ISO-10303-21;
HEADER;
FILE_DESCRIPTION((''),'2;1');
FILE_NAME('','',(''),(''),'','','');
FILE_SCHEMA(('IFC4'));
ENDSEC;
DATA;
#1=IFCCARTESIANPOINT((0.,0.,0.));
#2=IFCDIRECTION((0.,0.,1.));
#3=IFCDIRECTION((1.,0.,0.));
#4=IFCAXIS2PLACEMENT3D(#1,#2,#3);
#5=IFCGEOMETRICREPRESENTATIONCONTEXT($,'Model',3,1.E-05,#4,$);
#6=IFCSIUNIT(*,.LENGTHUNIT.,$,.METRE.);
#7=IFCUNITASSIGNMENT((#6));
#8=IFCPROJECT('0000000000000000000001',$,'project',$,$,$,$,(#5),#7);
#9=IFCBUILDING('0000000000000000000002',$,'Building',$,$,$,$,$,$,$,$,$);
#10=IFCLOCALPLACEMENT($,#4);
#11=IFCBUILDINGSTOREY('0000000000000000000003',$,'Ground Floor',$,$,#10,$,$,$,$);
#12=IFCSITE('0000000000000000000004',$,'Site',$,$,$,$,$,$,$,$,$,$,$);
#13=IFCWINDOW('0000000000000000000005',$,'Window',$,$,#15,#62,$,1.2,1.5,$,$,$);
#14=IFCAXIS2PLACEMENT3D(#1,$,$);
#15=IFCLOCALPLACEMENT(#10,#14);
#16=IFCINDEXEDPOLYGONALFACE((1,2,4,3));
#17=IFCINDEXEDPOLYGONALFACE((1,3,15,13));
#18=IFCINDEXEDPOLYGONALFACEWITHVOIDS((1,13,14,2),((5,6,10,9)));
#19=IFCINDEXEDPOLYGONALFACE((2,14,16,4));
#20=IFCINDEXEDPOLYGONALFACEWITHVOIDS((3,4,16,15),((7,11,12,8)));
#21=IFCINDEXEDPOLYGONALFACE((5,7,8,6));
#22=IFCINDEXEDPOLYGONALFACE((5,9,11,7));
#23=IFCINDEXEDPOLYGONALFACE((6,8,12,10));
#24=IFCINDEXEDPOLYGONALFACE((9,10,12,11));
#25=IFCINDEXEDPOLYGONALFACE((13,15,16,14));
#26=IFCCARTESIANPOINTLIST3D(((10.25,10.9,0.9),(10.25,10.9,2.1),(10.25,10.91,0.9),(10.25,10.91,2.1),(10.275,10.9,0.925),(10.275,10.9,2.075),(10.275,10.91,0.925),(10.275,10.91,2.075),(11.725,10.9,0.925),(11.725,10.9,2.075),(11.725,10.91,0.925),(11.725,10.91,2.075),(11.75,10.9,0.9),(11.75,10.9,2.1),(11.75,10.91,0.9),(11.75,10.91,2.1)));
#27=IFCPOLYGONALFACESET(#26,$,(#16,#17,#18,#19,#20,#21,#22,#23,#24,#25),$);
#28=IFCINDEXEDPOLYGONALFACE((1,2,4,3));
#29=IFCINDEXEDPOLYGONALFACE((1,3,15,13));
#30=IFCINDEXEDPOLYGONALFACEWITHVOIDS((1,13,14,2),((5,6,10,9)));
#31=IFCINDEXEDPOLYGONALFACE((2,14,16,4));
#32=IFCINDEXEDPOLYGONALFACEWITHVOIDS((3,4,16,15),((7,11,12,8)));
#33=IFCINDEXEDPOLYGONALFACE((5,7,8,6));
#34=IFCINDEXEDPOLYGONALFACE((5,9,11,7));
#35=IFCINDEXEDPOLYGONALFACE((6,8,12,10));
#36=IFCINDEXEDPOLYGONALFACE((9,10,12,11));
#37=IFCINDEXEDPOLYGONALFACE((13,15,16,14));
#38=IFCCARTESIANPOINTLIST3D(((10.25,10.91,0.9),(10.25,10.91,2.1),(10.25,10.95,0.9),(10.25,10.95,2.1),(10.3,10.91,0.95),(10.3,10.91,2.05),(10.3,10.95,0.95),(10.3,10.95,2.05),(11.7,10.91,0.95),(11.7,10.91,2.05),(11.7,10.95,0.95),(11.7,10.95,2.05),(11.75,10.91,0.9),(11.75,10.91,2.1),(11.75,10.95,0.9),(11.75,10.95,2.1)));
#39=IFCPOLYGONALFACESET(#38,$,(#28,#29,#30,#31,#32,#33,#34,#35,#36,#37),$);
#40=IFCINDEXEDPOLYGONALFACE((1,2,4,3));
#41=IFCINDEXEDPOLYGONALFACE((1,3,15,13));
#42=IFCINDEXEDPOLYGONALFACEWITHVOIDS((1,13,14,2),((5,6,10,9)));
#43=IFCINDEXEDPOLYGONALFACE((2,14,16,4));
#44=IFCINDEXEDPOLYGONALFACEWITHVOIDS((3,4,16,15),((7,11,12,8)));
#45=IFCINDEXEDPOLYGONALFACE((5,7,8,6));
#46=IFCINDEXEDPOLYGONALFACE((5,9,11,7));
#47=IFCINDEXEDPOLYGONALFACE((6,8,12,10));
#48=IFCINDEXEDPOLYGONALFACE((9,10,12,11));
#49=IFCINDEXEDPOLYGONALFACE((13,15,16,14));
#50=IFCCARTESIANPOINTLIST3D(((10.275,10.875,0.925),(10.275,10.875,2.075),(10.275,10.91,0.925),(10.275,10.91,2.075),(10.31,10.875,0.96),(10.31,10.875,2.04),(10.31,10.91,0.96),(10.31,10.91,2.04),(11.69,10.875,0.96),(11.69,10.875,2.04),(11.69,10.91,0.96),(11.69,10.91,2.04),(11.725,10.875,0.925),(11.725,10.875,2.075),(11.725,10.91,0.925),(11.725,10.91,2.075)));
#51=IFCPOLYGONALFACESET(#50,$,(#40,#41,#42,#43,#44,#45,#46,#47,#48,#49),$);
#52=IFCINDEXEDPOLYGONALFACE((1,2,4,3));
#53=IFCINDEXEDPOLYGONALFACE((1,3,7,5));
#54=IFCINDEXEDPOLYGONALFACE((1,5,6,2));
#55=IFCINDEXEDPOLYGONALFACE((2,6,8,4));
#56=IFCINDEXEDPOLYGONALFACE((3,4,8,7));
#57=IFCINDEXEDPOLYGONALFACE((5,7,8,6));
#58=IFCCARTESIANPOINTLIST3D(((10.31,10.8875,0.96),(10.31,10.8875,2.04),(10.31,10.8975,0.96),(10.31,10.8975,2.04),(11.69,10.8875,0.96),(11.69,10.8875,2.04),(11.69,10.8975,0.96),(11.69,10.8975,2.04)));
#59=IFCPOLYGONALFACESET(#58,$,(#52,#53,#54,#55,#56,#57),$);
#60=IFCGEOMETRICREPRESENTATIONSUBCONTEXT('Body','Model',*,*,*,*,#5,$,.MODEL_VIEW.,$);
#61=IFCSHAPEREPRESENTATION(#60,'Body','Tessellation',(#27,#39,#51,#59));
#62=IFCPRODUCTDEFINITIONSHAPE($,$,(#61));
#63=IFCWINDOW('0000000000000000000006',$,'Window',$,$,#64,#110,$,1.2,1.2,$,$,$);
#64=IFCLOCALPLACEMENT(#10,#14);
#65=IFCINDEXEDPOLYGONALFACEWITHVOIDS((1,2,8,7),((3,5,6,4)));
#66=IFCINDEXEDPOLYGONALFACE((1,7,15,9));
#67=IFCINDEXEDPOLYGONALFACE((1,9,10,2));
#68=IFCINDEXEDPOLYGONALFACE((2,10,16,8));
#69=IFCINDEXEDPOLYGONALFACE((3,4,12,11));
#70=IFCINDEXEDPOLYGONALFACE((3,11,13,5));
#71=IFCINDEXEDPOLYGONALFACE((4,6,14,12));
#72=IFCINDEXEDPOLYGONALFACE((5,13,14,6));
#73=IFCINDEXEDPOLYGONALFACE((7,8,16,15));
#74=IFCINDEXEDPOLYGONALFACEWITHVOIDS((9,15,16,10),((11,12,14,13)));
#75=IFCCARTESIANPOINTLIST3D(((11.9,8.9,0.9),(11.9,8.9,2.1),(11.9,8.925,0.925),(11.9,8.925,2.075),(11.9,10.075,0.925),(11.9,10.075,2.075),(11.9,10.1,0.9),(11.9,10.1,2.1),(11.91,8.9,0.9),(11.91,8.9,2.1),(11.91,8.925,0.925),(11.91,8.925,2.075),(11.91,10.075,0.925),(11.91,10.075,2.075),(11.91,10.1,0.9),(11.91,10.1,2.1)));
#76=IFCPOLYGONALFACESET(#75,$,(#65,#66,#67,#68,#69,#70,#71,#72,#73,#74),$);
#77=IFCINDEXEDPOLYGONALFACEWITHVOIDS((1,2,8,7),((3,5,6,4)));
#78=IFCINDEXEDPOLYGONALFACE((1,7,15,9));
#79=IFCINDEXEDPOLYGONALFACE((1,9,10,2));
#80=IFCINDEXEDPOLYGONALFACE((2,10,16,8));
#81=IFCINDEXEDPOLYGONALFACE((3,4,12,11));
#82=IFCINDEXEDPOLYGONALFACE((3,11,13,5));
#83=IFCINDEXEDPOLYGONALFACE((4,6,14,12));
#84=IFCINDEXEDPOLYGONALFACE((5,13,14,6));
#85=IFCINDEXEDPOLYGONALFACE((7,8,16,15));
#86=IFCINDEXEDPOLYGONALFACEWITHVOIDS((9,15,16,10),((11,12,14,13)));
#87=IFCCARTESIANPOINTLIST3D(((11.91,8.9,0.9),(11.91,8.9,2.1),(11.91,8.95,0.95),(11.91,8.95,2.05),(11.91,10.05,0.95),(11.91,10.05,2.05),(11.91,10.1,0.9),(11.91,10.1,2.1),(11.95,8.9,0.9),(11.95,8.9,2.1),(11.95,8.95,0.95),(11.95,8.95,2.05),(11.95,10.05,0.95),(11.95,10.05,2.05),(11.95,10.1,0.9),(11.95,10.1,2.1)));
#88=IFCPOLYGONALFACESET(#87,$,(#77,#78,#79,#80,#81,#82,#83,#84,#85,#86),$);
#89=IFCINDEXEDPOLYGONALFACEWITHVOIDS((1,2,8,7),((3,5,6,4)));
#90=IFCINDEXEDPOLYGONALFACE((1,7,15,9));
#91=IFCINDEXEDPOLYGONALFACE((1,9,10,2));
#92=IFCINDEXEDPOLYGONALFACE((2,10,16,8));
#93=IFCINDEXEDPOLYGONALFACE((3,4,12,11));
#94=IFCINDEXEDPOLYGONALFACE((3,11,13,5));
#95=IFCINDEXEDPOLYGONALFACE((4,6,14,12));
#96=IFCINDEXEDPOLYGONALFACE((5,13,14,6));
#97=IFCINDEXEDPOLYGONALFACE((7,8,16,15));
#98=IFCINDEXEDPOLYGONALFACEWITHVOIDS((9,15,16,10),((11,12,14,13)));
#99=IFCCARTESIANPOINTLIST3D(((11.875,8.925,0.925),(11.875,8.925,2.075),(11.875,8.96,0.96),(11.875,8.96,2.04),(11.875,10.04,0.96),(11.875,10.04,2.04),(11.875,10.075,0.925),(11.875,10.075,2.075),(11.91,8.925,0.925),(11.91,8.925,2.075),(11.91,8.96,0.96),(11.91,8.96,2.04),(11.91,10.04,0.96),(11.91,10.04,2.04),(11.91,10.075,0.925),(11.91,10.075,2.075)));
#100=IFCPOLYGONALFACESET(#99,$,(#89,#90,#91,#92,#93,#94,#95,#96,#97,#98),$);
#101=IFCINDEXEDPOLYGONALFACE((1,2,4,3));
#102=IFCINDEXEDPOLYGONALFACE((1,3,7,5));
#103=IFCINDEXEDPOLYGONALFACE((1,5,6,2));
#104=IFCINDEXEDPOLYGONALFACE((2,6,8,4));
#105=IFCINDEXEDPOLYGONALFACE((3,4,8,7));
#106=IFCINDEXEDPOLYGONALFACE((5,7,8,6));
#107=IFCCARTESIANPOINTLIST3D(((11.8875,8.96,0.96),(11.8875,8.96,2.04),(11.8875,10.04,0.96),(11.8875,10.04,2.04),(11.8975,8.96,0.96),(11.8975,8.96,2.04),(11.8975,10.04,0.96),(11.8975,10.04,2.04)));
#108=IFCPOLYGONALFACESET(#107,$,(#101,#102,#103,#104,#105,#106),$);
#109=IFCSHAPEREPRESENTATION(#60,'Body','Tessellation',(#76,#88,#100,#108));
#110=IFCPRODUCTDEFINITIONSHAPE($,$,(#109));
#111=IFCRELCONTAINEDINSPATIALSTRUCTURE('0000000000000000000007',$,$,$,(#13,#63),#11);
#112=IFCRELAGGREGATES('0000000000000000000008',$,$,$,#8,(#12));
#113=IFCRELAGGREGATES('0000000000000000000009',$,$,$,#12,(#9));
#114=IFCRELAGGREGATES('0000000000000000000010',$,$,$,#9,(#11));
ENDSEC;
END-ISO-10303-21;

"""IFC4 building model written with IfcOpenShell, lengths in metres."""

from ifc_helpers import new_model, si_unit, frame, origin_with_axes, place, context, subcontext, project, spatial, line, indexed_curve, outline, extrude, element, save


model = new_model("IFC4")

# Units and contexts
model_context = context("Model", 3, precision=1e-05, world=origin_with_axes())
body_context = subcontext(model_context, "Body", "Model", "MODEL_VIEW")
ifc_project = project(units=[si_unit("LENGTHUNIT", "METRE")], contexts=[model_context])

# Site, building, storey
site = spatial("IfcSite", under=ifc_project, Name="Site")
building = spatial("IfcBuilding", under=site, Name="Building")
storey_placement = place(None, origin_with_axes())
storey = spatial("IfcBuildingStorey", under=building, at=storey_placement, Name="Ground Floor")

# Windows
for number, where, z_axis, x_axis, name in (
    (1, (11.75, 11.0, 0.9), (0.0, 0.0, 1.0), (-1.0, 0.0, 0.0), "Window"),
):
    element("IfcWindow", number, at=place(storey_placement, frame(where, z_axis=z_axis, x_axis=x_axis)), inside=storey, Name=name, OverallHeight=1.2, OverallWidth=1.5, context=body_context, shape_type="SweptSolid", body=[
        extrude(outline(indexed_curve([(0.0, 0.0), (1.5, 0.0), (1.5, 1.2), (0.0, 1.2)], segments=[line(1, 2, 3, 4, 1)]), holes=[indexed_curve([(0.025, 0.025), (1.475, 0.025), (1.475, 1.175), (0.025, 1.175)], segments=[line(1, 2, 3, 4, 1)])]), frame((0.0, 0.09, 0.0), z_axis=(0.0, -1.0, 0.0), x_axis=(1.0, 0.0, 0.0)), (0.0, 0.0, -1.0), 0.01),
        extrude(outline(indexed_curve([(0.0, 0.0), (1.5, 0.0), (1.5, 1.2), (0.0, 1.2)], segments=[line(1, 2, 3, 4, 1)]), holes=[indexed_curve([(0.05, 0.05), (1.45, 0.05), (1.45, 1.15), (0.05, 1.15)], segments=[line(1, 2, 3, 4, 1)])]), frame((0.0, 0.05, 0.0), z_axis=(0.0, -1.0, 0.0), x_axis=(1.0, 0.0, 0.0)), (0.0, 0.0, -1.0), 0.04),
        extrude(outline(indexed_curve([(0.0, 0.0), (1.45, 0.0), (1.45, 1.15), (0.0, 1.15)], segments=[line(1, 2, 3, 4, 1)]), holes=[indexed_curve([(0.035, 0.035), (1.415, 0.035), (1.415, 1.115), (0.035, 1.115)], segments=[line(1, 2, 3, 4, 1)])]), frame((0.025, 0.09, 0.025), z_axis=(0.0, -1.0, 0.0), x_axis=(1.0, 0.0, 0.0)), (0.0, 0.0, -1.0), 0.035),
        extrude(outline(indexed_curve([(0.035, 0.035), (1.415, 0.035), (1.415, 1.115), (0.035, 1.115)], segments=[line(1, 2, 3, 4, 1)])), frame((0.025, 0.1025, 0.025), z_axis=(0.0, -1.0, 0.0), x_axis=(1.0, 0.0, 0.0)), (0.0, 0.0, -1.0), 0.01),
    ])
window_1_placement = place(storey_placement, frame((12.0, 8.9, 0.9), z_axis=(0.0, 0.0, 1.0), x_axis=(0.0, 1.0, 0.0)))
element("IfcWindow", 2, at=window_1_placement, inside=storey, Name="Window", OverallHeight=1.2, OverallWidth=1.2, context=body_context, shape_type="SweptSolid", body=[
    extrude(outline(indexed_curve([(0.0, 0.0), (1.2, 0.0), (1.2, 1.2), (0.0, 1.2)], segments=[line(1, 2, 3, 4, 1)]), holes=[indexed_curve([(0.025, 0.025), (1.175, 0.025), (1.175, 1.175), (0.025, 1.175)], segments=[line(1, 2, 3, 4, 1)])]), frame((0.0, 0.09, 0.0), z_axis=(0.0, -1.0, 0.0), x_axis=(1.0, 0.0, 0.0)), (0.0, 0.0, -1.0), 0.01),
    extrude(outline(indexed_curve([(0.0, 0.0), (1.2, 0.0), (1.2, 1.2), (0.0, 1.2)], segments=[line(1, 2, 3, 4, 1)]), holes=[indexed_curve([(0.05, 0.05), (1.15, 0.05), (1.15, 1.15), (0.05, 1.15)], segments=[line(1, 2, 3, 4, 1)])]), frame((0.0, 0.05, 0.0), z_axis=(0.0, -1.0, 0.0), x_axis=(1.0, 0.0, 0.0)), (0.0, 0.0, -1.0), 0.04),
    extrude(outline(indexed_curve([(0.0, 0.0), (1.15, 0.0), (1.15, 1.15), (0.0, 1.15)], segments=[line(1, 2, 3, 4, 1)]), holes=[indexed_curve([(0.035, 0.035), (1.115, 0.035), (1.115, 1.115), (0.035, 1.115)], segments=[line(1, 2, 3, 4, 1)])]), frame((0.025, 0.09, 0.025), z_axis=(0.0, -1.0, 0.0), x_axis=(1.0, 0.0, 0.0)), (0.0, 0.0, -1.0), 0.035),
    extrude(outline(indexed_curve([(0.035, 0.035), (1.115, 0.035), (1.115, 1.115), (0.035, 1.115)], segments=[line(1, 2, 3, 4, 1)])), frame((0.025, 0.1025, 0.025), z_axis=(0.0, -1.0, 0.0), x_axis=(1.0, 0.0, 0.0)), (0.0, 0.0, -1.0), 0.01),
])

save(model, "model.ifc")
